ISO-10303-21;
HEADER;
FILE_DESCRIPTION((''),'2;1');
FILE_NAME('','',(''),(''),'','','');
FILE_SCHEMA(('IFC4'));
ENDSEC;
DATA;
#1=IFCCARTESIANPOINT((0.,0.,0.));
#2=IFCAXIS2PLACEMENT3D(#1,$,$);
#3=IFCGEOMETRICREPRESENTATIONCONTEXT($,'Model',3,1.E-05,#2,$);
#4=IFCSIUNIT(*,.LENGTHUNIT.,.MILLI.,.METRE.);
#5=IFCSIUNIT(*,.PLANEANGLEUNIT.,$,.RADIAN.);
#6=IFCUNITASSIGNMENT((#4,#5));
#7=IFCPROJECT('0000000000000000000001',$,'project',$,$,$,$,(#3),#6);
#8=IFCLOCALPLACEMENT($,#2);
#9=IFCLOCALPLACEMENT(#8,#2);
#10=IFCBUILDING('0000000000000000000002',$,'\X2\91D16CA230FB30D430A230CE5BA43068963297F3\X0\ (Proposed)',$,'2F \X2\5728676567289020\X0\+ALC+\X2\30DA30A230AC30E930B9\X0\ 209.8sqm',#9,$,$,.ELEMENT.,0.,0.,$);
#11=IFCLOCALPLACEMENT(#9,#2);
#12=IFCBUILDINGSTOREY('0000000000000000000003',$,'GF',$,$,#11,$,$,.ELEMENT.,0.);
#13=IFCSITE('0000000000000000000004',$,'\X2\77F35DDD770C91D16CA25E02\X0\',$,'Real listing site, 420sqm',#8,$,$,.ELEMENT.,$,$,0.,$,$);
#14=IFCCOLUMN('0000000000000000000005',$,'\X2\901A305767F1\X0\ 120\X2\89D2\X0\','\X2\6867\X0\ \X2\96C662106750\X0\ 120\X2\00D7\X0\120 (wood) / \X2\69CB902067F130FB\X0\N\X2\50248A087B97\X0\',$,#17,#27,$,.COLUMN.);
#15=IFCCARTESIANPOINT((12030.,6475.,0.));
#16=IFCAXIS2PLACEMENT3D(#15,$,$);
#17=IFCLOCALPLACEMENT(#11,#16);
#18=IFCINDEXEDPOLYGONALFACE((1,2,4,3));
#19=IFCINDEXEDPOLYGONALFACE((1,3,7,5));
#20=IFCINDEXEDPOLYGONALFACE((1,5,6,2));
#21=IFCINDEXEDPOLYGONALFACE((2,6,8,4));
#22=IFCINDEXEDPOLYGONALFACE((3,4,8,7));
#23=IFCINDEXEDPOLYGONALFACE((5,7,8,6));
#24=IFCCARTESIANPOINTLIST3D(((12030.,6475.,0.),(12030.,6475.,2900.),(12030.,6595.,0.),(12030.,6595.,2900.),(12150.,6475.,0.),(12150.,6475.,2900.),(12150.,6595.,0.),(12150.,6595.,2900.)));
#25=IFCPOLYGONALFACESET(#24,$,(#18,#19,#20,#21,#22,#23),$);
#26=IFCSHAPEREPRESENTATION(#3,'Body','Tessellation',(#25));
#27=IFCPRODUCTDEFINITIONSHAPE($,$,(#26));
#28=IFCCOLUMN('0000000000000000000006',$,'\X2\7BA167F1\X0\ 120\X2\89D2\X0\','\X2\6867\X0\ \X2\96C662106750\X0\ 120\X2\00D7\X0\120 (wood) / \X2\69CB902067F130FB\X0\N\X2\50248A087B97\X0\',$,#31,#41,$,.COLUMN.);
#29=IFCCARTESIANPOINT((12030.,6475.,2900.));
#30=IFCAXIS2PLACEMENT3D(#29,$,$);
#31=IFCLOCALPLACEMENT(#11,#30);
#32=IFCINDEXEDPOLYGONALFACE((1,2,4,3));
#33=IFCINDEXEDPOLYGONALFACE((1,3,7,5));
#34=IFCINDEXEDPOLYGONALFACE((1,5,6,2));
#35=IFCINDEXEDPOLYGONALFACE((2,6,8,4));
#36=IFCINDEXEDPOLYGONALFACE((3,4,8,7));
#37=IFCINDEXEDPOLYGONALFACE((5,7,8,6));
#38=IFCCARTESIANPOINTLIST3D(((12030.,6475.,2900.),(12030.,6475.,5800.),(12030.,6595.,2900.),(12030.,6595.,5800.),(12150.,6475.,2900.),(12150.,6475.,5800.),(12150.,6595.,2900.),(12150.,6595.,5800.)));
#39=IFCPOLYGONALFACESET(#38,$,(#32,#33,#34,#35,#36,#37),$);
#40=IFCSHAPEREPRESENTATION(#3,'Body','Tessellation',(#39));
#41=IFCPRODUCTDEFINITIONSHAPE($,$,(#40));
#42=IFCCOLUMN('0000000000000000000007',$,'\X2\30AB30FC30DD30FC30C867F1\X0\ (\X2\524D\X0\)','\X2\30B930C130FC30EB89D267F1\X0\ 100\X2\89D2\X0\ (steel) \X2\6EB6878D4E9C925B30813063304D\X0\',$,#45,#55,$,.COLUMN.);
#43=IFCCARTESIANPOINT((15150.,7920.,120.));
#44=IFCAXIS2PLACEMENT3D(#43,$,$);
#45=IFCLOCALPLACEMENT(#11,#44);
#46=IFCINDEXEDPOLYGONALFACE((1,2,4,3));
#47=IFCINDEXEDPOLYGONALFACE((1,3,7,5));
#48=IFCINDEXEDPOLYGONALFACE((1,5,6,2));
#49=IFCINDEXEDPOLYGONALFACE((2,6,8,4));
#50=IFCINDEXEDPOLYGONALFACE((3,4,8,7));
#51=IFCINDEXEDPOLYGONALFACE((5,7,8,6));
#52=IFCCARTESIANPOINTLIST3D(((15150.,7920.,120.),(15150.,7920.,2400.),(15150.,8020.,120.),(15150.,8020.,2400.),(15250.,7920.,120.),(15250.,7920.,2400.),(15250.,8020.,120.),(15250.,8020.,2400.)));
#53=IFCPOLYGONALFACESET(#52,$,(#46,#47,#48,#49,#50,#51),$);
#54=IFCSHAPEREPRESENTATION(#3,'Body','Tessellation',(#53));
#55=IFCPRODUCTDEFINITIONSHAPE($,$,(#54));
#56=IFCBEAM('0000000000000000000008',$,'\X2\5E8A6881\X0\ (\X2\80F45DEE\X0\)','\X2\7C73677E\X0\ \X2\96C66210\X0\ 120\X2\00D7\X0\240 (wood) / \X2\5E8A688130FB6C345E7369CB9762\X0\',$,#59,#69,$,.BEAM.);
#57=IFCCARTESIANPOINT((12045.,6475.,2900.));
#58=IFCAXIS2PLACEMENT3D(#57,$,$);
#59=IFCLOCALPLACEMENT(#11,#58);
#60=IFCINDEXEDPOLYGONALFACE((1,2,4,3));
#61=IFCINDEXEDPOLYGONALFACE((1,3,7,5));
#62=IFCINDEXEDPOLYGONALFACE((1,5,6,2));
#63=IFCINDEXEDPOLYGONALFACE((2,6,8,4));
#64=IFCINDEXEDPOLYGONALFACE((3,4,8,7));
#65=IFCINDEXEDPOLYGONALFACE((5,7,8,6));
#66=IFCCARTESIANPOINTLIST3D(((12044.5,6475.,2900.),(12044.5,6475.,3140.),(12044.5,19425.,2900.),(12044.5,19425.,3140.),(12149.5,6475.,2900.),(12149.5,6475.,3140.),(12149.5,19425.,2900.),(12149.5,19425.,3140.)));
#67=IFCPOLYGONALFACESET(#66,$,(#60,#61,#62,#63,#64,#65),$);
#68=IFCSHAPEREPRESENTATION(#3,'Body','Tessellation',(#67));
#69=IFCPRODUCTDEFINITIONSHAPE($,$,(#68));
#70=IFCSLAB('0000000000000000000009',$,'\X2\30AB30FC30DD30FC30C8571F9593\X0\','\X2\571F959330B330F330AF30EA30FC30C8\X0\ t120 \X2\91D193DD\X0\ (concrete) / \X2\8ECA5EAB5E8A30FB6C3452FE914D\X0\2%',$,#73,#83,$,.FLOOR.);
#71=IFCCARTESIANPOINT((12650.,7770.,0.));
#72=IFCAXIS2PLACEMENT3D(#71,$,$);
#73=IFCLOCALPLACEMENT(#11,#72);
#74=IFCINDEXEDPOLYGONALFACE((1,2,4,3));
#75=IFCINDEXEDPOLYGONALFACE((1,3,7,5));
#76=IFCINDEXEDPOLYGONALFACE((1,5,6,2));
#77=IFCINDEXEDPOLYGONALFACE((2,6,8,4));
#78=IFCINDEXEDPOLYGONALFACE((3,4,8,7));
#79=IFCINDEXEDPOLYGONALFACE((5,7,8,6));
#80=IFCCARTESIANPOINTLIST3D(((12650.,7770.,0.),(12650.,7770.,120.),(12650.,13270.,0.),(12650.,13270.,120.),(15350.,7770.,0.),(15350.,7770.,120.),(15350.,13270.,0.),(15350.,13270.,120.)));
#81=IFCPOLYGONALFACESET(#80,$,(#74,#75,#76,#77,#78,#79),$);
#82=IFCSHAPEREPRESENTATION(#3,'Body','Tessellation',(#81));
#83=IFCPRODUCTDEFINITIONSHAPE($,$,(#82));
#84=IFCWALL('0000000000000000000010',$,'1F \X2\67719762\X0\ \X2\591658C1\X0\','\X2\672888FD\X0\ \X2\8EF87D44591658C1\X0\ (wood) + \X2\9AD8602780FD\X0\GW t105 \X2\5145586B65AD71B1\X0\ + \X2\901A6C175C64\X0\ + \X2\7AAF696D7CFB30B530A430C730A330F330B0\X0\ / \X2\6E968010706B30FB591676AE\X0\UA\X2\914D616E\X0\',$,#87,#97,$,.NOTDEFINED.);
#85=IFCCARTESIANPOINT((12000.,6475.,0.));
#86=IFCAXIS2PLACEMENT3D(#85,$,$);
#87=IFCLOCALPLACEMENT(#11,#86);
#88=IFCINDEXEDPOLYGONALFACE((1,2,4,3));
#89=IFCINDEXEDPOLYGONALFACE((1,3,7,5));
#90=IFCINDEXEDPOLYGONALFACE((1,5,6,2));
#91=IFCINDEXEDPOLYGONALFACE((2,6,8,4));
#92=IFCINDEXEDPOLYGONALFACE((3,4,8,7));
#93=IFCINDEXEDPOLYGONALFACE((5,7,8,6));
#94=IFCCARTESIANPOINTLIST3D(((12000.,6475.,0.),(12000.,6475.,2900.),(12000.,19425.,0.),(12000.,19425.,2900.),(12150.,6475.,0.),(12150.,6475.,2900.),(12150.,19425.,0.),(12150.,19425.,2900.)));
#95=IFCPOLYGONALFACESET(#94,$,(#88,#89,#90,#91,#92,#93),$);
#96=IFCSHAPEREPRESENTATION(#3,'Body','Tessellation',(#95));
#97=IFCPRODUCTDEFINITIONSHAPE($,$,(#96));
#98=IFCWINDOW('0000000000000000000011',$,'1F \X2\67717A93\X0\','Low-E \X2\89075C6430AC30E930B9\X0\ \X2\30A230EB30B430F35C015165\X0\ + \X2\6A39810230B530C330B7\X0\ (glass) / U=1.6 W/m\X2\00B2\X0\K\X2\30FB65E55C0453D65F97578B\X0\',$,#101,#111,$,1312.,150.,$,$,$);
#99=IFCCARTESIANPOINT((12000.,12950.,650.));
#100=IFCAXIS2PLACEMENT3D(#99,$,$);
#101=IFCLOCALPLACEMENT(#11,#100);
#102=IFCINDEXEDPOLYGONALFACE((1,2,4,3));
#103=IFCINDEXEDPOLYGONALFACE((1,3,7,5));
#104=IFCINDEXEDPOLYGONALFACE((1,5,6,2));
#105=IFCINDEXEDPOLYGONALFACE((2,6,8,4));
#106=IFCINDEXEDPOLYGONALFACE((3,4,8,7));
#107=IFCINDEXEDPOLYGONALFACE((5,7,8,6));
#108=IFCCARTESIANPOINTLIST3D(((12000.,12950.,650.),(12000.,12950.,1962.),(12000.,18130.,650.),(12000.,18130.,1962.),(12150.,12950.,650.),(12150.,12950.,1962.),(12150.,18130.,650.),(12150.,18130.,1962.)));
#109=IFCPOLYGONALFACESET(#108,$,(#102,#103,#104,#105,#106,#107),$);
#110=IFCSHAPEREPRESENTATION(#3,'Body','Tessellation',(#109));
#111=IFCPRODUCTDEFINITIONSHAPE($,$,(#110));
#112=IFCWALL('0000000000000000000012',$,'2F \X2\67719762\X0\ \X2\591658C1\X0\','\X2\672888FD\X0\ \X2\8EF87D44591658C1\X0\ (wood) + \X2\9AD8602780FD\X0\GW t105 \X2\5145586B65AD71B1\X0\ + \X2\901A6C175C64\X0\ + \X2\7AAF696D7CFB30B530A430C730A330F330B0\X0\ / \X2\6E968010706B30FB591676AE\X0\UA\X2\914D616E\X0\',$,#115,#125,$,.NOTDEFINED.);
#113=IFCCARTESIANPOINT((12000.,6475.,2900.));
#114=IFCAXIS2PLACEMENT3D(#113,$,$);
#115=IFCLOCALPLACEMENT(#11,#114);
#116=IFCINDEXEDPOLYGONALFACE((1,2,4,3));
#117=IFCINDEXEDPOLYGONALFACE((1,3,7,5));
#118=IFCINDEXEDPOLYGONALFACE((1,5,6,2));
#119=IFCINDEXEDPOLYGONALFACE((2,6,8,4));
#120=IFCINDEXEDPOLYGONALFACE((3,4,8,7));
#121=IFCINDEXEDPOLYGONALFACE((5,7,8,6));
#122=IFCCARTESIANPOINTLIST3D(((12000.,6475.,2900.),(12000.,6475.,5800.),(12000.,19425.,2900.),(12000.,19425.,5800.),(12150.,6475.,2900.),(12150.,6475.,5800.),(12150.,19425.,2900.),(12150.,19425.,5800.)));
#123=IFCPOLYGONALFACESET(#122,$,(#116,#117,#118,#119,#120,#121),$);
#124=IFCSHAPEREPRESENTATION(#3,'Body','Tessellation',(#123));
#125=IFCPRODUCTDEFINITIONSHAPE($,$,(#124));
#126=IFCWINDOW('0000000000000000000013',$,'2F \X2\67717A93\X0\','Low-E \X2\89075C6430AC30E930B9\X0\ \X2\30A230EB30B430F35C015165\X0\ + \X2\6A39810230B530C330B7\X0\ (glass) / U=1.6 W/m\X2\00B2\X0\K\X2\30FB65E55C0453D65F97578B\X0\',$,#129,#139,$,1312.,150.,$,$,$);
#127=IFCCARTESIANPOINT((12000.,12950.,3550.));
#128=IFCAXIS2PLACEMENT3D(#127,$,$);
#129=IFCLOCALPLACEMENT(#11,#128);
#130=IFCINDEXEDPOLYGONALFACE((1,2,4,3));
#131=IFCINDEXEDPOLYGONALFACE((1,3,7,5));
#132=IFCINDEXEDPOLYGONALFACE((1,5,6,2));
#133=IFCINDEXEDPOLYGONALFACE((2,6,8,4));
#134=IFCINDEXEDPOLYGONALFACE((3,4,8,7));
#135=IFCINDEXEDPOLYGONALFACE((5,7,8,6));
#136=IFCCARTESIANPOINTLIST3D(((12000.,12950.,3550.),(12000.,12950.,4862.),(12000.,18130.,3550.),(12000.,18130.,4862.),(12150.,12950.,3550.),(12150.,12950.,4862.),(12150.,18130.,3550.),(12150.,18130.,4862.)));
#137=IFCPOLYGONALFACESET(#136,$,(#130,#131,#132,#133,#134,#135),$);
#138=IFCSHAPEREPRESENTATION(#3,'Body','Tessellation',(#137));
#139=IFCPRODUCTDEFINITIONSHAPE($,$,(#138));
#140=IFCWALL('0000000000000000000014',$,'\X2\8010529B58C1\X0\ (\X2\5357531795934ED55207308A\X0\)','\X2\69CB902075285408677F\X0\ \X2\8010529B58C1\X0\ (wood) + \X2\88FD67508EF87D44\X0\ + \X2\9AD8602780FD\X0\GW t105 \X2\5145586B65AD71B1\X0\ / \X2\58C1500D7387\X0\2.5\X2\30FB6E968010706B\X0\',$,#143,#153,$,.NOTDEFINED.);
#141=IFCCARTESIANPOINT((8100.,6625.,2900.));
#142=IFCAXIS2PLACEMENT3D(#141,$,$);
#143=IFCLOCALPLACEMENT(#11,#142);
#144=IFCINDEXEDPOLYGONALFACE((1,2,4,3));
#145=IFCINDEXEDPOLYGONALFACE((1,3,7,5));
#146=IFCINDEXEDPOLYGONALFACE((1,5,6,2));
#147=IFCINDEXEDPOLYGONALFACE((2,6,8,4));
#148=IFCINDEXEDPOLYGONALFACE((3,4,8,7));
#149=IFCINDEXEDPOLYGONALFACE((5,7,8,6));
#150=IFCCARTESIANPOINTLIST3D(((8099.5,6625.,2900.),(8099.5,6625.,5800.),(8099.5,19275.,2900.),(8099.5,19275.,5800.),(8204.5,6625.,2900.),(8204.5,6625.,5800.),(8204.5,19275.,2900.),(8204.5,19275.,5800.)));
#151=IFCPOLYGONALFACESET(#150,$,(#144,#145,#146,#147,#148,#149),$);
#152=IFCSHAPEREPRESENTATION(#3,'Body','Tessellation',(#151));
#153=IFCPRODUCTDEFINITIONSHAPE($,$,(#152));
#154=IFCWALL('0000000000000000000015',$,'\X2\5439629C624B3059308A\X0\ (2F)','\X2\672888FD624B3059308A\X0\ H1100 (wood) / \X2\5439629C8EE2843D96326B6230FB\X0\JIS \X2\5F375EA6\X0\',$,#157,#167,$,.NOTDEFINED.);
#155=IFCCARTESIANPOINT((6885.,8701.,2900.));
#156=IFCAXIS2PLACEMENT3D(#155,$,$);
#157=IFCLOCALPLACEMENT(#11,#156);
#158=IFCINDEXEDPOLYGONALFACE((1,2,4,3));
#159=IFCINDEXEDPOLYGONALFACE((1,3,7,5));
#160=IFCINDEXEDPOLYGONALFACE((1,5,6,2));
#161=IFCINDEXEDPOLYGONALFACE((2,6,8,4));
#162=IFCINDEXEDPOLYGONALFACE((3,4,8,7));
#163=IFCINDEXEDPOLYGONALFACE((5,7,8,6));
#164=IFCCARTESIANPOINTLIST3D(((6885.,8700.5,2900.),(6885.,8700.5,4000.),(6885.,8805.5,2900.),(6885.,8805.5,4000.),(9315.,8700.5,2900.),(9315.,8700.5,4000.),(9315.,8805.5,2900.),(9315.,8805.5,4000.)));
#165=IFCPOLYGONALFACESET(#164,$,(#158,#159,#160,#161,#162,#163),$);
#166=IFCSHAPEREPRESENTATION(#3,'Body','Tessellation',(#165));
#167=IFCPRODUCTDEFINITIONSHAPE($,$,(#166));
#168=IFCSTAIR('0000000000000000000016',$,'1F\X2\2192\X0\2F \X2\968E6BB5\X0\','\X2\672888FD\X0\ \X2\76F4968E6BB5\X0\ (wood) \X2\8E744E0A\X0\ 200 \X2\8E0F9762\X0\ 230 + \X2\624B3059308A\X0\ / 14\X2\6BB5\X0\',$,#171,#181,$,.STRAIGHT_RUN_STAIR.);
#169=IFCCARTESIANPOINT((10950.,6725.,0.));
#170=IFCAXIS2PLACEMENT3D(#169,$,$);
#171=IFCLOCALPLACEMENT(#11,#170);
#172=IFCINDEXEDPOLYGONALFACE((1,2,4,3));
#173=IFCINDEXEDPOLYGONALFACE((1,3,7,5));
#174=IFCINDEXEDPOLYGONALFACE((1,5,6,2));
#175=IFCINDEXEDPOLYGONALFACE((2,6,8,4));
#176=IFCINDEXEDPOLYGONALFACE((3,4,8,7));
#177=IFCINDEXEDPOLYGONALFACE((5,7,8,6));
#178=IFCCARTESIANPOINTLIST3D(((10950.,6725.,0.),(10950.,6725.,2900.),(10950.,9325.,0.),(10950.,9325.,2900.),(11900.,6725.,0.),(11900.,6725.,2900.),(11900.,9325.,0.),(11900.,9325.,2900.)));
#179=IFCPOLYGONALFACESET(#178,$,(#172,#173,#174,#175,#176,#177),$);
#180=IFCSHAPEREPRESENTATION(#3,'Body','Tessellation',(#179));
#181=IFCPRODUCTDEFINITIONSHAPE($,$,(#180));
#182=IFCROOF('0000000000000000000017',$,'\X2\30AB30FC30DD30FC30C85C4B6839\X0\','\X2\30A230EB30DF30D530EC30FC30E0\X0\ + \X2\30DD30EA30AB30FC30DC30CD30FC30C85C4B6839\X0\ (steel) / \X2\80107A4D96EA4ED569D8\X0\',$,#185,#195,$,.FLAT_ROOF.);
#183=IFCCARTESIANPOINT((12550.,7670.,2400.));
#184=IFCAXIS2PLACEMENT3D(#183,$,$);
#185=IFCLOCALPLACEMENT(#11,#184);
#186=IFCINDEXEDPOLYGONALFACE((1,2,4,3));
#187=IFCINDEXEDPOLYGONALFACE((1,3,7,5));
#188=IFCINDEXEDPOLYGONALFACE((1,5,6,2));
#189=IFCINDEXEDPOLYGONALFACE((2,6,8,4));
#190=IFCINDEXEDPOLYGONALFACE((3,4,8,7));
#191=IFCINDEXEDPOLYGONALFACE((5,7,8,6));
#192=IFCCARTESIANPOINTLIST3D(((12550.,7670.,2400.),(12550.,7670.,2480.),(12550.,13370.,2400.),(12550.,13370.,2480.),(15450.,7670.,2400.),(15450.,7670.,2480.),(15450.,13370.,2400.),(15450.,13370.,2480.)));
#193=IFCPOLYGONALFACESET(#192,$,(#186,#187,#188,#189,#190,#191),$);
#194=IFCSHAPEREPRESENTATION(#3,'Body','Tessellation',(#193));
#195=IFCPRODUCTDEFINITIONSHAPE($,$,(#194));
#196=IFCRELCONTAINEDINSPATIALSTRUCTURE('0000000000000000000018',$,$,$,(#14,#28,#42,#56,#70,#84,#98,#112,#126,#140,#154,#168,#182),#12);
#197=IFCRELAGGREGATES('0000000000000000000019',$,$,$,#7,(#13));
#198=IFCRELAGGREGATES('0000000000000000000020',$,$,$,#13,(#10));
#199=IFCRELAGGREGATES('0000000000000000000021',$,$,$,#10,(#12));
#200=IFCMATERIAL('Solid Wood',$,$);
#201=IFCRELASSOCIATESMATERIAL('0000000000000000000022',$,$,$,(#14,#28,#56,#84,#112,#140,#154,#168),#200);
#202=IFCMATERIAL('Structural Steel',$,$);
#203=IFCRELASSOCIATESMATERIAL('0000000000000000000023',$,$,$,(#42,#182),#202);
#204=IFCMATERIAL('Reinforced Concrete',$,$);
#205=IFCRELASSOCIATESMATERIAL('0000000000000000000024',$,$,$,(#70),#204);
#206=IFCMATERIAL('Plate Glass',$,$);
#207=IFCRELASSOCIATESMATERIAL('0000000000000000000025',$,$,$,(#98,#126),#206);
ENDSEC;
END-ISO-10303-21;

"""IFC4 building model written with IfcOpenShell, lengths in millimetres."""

from ifc_helpers import new_model, si_unit, frame, frame_2d, origin, place, context, project, spatial, rectangle, extrude, material, element, fill, save


model = new_model("IFC4")

# Units and contexts
model_context = context("Model", 3, precision=1e-05, world=origin())
ifc_project = project(units=[si_unit("LENGTHUNIT", "METRE", prefix="MILLI"), si_unit("PLANEANGLEUNIT", "RADIAN")], contexts=[model_context])

# Site, building, storey
site_placement = place(None, origin())
site = spatial("IfcSite", under=ifc_project, at=site_placement, Name="石川県金沢市", ObjectType="Real listing site, 420sqm", CompositionType="ELEMENT", RefElevation=0.0)
building_placement = place(site_placement, origin())
building = spatial("IfcBuilding", under=site, at=building_placement, Name="金沢・ピアノ室と防音 (Proposed)", ObjectType="2F 在来木造+ALC+ペアガラス 209.8sqm", CompositionType="ELEMENT", ElevationOfRefHeight=0.0, ElevationOfTerrain=0.0)
storey_placement = place(building_placement, origin())
storey = spatial("IfcBuildingStorey", under=building, at=storey_placement, Name="GF", CompositionType="ELEMENT", Elevation=0.0)

# Columns
ifc_material_1 = material(Name="Solid Wood")
column_1_placement = place(storey_placement, frame((12030.0, 6475.0, 0.0)))
element("IfcColumn", 1, at=column_1_placement, inside=storey, material=ifc_material_1, Name="通し柱 120角", Description="桧 集成材 120×120 (wood) / 構造柱・N値計算", PredefinedType="COLUMN", context=model_context, shape_type="SweptSolid", body=[
    extrude(rectangle(XDim=120.0, YDim=120.0, at=frame_2d((60.0, 60.0))), frame((12030.0, 6475.0, 0.0)), (0.0, 0.0, 1.0), 2900.0),
])
column_2_placement = place(storey_placement, frame((12030.0, 6475.0, 2900.0)))
element("IfcColumn", 2, at=column_2_placement, inside=storey, material=ifc_material_1, Name="管柱 120角", Description="桧 集成材 120×120 (wood) / 構造柱・N値計算", PredefinedType="COLUMN", context=model_context, shape_type="SweptSolid", body=[
    extrude(rectangle(XDim=120.0, YDim=120.0, at=frame_2d((60.0, 60.0))), frame((12030.0, 6475.0, 2900.0)), (0.0, 0.0, 1.0), 2900.0),
])
ifc_material_2 = material(Name="Structural Steel")
column_3_placement = place(storey_placement, frame((15150.0, 7920.0, 120.0)))
element("IfcColumn", 3, at=column_3_placement, inside=storey, material=ifc_material_2, Name="カーポート柱 (前)", Description="スチール角柱 100角 (steel) 溶融亜鉛めっき", PredefinedType="COLUMN", context=model_context, shape_type="SweptSolid", body=[
    extrude(rectangle(XDim=100.0, YDim=100.0, at=frame_2d((50.0, 50.0))), frame((15150.0, 7920.0, 120.0)), (0.0, 0.0, 1.0), 2280.0),
])

# Beam
beam_1_placement = place(storey_placement, frame((12045.0, 6475.0, 2900.0)))
element("IfcBeam", 4, at=beam_1_placement, inside=storey, material=ifc_material_1, Name="床梁 (胴差)", Description="米松 集成 120×240 (wood) / 床梁・水平構面", PredefinedType="BEAM", context=model_context, shape_type="SweptSolid", body=[
    extrude(rectangle(XDim=105.0, YDim=12950.0, at=frame_2d((52.0, 6475.0))), frame((12045.0, 6475.0, 2900.0)), (0.0, 0.0, 1.0), 240.0),
])

# Slab
ifc_material_3 = material(Name="Reinforced Concrete")
slab_placement = place(storey_placement, frame((12650.0, 7770.0, 0.0)))
element("IfcSlab", 5, at=slab_placement, inside=storey, material=ifc_material_3, Name="カーポート土間", Description="土間コンクリート t120 金鏝 (concrete) / 車庫床・水勾配2%", PredefinedType="FLOOR", context=model_context, shape_type="SweptSolid", body=[
    extrude(rectangle(XDim=2700.0, YDim=5500.0, at=frame_2d((1350.0, 2750.0))), frame((12650.0, 7770.0, 0.0)), (0.0, 0.0, 1.0), 120.0),
])

# Wall, opening, window
wall_1_placement = place(storey_placement, frame((12000.0, 6475.0, 0.0)))
wall_1 = element("IfcWall", 6, at=wall_1_placement, inside=storey, material=ifc_material_1, Name="1F 東面 外壁", Description="木製 軸組外壁 (wood) + 高性能GW t105 充填断熱 + 通気層 + 窯業系サイディング / 準耐火・外皮UA配慮", PredefinedType="NOTDEFINED", context=model_context, shape_type="SweptSolid", body=[
    extrude(rectangle(XDim=150.0, YDim=12950.0, at=frame_2d((75.0, 6475.0))), frame((12000.0, 6475.0, 0.0)), (0.0, 0.0, 1.0), 2900.0),
])
opening_1_placement = place(storey_placement, frame((12000.0, 12950.0, 650.0)))
opening_1 = element("IfcOpeningElement", 7, at=opening_1_placement, cuts=wall_1, PredefinedType="NOTDEFINED", context=model_context, shape_type="SweptSolid", body=[
    extrude(rectangle(XDim=150.0, YDim=5180.0, at=frame_2d((75.0, 2590.0))), frame((12000.0, 12950.0, 650.0)), (0.0, 0.0, 1.0), 1312.0),
])
ifc_material_4 = material(Name="Plate Glass")
window_1_placement = place(storey_placement, frame((12000.0, 12950.0, 650.0)))
window_1 = element("IfcWindow", 8, at=window_1_placement, inside=storey, material=ifc_material_4, Name="1F 東窓", Description="Low-E 複層ガラス アルゴン封入 + 樹脂サッシ (glass) / U=1.6 W/m²K・日射取得型", OverallHeight=1312.0, OverallWidth=150.0, context=model_context, shape_type="SweptSolid", body=[
    extrude(rectangle(XDim=150.0, YDim=5180.0, at=frame_2d((75.0, 2590.0))), frame((12000.0, 12950.0, 650.0)), (0.0, 0.0, 1.0), 1312.0),
])
fill(opening_1, window_1)

# Wall, opening, window
wall_2_placement = place(storey_placement, frame((12000.0, 6475.0, 2900.0)))
wall_2 = element("IfcWall", 9, at=wall_2_placement, inside=storey, material=ifc_material_1, Name="2F 東面 外壁", Description="木製 軸組外壁 (wood) + 高性能GW t105 充填断熱 + 通気層 + 窯業系サイディング / 準耐火・外皮UA配慮", PredefinedType="NOTDEFINED", context=model_context, shape_type="SweptSolid", body=[
    extrude(rectangle(XDim=150.0, YDim=12950.0, at=frame_2d((75.0, 6475.0))), frame((12000.0, 6475.0, 2900.0)), (0.0, 0.0, 1.0), 2900.0),
])
opening_2_placement = place(storey_placement, frame((12000.0, 12950.0, 3550.0)))
opening_2 = element("IfcOpeningElement", 10, at=opening_2_placement, cuts=wall_2, PredefinedType="NOTDEFINED", context=model_context, shape_type="SweptSolid", body=[
    extrude(rectangle(XDim=150.0, YDim=5180.0, at=frame_2d((75.0, 2590.0))), frame((12000.0, 12950.0, 3550.0)), (0.0, 0.0, 1.0), 1312.0),
])
window_2_placement = place(storey_placement, frame((12000.0, 12950.0, 3550.0)))
window_2 = element("IfcWindow", 11, at=window_2_placement, inside=storey, material=ifc_material_4, Name="2F 東窓", Description="Low-E 複層ガラス アルゴン封入 + 樹脂サッシ (glass) / U=1.6 W/m²K・日射取得型", OverallHeight=1312.0, OverallWidth=150.0, context=model_context, shape_type="SweptSolid", body=[
    extrude(rectangle(XDim=150.0, YDim=5180.0, at=frame_2d((75.0, 2590.0))), frame((12000.0, 12950.0, 3550.0)), (0.0, 0.0, 1.0), 1312.0),
])
fill(opening_2, window_2)

# Walls
wall_3_placement = place(storey_placement, frame((8100.0, 6625.0, 2900.0)))
element("IfcWall", 12, at=wall_3_placement, inside=storey, material=ifc_material_1, Name="耐力壁 (南北間仕切り)", Description="構造用合板 耐力壁 (wood) + 製材軸組 + 高性能GW t105 充填断熱 / 壁倍率2.5・準耐火", PredefinedType="NOTDEFINED", context=model_context, shape_type="SweptSolid", body=[
    extrude(rectangle(XDim=105.0, YDim=12650.0, at=frame_2d((52.0, 6325.0))), frame((8100.0, 6625.0, 2900.0)), (0.0, 0.0, 1.0), 2900.0),
])
wall_4_placement = place(storey_placement, frame((6885.0, 8701.0, 2900.0)))
element("IfcWall", 13, at=wall_4_placement, inside=storey, material=ifc_material_1, Name="吹抜手すり (2F)", Description="木製手すり H1100 (wood) / 吹抜転落防止・JIS 強度", PredefinedType="NOTDEFINED", context=model_context, shape_type="SweptSolid", body=[
    extrude(rectangle(XDim=2430.0, YDim=105.0, at=frame_2d((1215.0, 52.0))), frame((6885.0, 8701.0, 2900.0)), (0.0, 0.0, 1.0), 1100.0),
])

# Stair
stair_placement = place(storey_placement, frame((10950.0, 6725.0, 0.0)))
element("IfcStair", 14, at=stair_placement, inside=storey, material=ifc_material_1, Name="1F→2F 階段", Description="木製 直階段 (wood) 蹴上 200 踏面 230 + 手すり / 14段", PredefinedType="STRAIGHT_RUN_STAIR", context=model_context, shape_type="SweptSolid", body=[
    extrude(rectangle(XDim=950.0, YDim=2600.0, at=frame_2d((475.0, 1300.0))), frame((10950.0, 6725.0, 0.0)), (0.0, 0.0, 1.0), 2900.0),
])

# Roof
roof_placement = place(storey_placement, frame((12550.0, 7670.0, 2400.0)))
element("IfcRoof", 15, at=roof_placement, inside=storey, material=ifc_material_2, Name="カーポート屋根", Description="アルミフレーム + ポリカーボネート屋根 (steel) / 耐積雪仕様", PredefinedType="FLAT_ROOF", context=model_context, shape_type="SweptSolid", body=[
    extrude(rectangle(XDim=2900.0, YDim=5700.0, at=frame_2d((1450.0, 2850.0))), frame((12550.0, 7670.0, 2400.0)), (0.0, 0.0, 1.0), 80.0),
])

save(model, "model.ifc")
